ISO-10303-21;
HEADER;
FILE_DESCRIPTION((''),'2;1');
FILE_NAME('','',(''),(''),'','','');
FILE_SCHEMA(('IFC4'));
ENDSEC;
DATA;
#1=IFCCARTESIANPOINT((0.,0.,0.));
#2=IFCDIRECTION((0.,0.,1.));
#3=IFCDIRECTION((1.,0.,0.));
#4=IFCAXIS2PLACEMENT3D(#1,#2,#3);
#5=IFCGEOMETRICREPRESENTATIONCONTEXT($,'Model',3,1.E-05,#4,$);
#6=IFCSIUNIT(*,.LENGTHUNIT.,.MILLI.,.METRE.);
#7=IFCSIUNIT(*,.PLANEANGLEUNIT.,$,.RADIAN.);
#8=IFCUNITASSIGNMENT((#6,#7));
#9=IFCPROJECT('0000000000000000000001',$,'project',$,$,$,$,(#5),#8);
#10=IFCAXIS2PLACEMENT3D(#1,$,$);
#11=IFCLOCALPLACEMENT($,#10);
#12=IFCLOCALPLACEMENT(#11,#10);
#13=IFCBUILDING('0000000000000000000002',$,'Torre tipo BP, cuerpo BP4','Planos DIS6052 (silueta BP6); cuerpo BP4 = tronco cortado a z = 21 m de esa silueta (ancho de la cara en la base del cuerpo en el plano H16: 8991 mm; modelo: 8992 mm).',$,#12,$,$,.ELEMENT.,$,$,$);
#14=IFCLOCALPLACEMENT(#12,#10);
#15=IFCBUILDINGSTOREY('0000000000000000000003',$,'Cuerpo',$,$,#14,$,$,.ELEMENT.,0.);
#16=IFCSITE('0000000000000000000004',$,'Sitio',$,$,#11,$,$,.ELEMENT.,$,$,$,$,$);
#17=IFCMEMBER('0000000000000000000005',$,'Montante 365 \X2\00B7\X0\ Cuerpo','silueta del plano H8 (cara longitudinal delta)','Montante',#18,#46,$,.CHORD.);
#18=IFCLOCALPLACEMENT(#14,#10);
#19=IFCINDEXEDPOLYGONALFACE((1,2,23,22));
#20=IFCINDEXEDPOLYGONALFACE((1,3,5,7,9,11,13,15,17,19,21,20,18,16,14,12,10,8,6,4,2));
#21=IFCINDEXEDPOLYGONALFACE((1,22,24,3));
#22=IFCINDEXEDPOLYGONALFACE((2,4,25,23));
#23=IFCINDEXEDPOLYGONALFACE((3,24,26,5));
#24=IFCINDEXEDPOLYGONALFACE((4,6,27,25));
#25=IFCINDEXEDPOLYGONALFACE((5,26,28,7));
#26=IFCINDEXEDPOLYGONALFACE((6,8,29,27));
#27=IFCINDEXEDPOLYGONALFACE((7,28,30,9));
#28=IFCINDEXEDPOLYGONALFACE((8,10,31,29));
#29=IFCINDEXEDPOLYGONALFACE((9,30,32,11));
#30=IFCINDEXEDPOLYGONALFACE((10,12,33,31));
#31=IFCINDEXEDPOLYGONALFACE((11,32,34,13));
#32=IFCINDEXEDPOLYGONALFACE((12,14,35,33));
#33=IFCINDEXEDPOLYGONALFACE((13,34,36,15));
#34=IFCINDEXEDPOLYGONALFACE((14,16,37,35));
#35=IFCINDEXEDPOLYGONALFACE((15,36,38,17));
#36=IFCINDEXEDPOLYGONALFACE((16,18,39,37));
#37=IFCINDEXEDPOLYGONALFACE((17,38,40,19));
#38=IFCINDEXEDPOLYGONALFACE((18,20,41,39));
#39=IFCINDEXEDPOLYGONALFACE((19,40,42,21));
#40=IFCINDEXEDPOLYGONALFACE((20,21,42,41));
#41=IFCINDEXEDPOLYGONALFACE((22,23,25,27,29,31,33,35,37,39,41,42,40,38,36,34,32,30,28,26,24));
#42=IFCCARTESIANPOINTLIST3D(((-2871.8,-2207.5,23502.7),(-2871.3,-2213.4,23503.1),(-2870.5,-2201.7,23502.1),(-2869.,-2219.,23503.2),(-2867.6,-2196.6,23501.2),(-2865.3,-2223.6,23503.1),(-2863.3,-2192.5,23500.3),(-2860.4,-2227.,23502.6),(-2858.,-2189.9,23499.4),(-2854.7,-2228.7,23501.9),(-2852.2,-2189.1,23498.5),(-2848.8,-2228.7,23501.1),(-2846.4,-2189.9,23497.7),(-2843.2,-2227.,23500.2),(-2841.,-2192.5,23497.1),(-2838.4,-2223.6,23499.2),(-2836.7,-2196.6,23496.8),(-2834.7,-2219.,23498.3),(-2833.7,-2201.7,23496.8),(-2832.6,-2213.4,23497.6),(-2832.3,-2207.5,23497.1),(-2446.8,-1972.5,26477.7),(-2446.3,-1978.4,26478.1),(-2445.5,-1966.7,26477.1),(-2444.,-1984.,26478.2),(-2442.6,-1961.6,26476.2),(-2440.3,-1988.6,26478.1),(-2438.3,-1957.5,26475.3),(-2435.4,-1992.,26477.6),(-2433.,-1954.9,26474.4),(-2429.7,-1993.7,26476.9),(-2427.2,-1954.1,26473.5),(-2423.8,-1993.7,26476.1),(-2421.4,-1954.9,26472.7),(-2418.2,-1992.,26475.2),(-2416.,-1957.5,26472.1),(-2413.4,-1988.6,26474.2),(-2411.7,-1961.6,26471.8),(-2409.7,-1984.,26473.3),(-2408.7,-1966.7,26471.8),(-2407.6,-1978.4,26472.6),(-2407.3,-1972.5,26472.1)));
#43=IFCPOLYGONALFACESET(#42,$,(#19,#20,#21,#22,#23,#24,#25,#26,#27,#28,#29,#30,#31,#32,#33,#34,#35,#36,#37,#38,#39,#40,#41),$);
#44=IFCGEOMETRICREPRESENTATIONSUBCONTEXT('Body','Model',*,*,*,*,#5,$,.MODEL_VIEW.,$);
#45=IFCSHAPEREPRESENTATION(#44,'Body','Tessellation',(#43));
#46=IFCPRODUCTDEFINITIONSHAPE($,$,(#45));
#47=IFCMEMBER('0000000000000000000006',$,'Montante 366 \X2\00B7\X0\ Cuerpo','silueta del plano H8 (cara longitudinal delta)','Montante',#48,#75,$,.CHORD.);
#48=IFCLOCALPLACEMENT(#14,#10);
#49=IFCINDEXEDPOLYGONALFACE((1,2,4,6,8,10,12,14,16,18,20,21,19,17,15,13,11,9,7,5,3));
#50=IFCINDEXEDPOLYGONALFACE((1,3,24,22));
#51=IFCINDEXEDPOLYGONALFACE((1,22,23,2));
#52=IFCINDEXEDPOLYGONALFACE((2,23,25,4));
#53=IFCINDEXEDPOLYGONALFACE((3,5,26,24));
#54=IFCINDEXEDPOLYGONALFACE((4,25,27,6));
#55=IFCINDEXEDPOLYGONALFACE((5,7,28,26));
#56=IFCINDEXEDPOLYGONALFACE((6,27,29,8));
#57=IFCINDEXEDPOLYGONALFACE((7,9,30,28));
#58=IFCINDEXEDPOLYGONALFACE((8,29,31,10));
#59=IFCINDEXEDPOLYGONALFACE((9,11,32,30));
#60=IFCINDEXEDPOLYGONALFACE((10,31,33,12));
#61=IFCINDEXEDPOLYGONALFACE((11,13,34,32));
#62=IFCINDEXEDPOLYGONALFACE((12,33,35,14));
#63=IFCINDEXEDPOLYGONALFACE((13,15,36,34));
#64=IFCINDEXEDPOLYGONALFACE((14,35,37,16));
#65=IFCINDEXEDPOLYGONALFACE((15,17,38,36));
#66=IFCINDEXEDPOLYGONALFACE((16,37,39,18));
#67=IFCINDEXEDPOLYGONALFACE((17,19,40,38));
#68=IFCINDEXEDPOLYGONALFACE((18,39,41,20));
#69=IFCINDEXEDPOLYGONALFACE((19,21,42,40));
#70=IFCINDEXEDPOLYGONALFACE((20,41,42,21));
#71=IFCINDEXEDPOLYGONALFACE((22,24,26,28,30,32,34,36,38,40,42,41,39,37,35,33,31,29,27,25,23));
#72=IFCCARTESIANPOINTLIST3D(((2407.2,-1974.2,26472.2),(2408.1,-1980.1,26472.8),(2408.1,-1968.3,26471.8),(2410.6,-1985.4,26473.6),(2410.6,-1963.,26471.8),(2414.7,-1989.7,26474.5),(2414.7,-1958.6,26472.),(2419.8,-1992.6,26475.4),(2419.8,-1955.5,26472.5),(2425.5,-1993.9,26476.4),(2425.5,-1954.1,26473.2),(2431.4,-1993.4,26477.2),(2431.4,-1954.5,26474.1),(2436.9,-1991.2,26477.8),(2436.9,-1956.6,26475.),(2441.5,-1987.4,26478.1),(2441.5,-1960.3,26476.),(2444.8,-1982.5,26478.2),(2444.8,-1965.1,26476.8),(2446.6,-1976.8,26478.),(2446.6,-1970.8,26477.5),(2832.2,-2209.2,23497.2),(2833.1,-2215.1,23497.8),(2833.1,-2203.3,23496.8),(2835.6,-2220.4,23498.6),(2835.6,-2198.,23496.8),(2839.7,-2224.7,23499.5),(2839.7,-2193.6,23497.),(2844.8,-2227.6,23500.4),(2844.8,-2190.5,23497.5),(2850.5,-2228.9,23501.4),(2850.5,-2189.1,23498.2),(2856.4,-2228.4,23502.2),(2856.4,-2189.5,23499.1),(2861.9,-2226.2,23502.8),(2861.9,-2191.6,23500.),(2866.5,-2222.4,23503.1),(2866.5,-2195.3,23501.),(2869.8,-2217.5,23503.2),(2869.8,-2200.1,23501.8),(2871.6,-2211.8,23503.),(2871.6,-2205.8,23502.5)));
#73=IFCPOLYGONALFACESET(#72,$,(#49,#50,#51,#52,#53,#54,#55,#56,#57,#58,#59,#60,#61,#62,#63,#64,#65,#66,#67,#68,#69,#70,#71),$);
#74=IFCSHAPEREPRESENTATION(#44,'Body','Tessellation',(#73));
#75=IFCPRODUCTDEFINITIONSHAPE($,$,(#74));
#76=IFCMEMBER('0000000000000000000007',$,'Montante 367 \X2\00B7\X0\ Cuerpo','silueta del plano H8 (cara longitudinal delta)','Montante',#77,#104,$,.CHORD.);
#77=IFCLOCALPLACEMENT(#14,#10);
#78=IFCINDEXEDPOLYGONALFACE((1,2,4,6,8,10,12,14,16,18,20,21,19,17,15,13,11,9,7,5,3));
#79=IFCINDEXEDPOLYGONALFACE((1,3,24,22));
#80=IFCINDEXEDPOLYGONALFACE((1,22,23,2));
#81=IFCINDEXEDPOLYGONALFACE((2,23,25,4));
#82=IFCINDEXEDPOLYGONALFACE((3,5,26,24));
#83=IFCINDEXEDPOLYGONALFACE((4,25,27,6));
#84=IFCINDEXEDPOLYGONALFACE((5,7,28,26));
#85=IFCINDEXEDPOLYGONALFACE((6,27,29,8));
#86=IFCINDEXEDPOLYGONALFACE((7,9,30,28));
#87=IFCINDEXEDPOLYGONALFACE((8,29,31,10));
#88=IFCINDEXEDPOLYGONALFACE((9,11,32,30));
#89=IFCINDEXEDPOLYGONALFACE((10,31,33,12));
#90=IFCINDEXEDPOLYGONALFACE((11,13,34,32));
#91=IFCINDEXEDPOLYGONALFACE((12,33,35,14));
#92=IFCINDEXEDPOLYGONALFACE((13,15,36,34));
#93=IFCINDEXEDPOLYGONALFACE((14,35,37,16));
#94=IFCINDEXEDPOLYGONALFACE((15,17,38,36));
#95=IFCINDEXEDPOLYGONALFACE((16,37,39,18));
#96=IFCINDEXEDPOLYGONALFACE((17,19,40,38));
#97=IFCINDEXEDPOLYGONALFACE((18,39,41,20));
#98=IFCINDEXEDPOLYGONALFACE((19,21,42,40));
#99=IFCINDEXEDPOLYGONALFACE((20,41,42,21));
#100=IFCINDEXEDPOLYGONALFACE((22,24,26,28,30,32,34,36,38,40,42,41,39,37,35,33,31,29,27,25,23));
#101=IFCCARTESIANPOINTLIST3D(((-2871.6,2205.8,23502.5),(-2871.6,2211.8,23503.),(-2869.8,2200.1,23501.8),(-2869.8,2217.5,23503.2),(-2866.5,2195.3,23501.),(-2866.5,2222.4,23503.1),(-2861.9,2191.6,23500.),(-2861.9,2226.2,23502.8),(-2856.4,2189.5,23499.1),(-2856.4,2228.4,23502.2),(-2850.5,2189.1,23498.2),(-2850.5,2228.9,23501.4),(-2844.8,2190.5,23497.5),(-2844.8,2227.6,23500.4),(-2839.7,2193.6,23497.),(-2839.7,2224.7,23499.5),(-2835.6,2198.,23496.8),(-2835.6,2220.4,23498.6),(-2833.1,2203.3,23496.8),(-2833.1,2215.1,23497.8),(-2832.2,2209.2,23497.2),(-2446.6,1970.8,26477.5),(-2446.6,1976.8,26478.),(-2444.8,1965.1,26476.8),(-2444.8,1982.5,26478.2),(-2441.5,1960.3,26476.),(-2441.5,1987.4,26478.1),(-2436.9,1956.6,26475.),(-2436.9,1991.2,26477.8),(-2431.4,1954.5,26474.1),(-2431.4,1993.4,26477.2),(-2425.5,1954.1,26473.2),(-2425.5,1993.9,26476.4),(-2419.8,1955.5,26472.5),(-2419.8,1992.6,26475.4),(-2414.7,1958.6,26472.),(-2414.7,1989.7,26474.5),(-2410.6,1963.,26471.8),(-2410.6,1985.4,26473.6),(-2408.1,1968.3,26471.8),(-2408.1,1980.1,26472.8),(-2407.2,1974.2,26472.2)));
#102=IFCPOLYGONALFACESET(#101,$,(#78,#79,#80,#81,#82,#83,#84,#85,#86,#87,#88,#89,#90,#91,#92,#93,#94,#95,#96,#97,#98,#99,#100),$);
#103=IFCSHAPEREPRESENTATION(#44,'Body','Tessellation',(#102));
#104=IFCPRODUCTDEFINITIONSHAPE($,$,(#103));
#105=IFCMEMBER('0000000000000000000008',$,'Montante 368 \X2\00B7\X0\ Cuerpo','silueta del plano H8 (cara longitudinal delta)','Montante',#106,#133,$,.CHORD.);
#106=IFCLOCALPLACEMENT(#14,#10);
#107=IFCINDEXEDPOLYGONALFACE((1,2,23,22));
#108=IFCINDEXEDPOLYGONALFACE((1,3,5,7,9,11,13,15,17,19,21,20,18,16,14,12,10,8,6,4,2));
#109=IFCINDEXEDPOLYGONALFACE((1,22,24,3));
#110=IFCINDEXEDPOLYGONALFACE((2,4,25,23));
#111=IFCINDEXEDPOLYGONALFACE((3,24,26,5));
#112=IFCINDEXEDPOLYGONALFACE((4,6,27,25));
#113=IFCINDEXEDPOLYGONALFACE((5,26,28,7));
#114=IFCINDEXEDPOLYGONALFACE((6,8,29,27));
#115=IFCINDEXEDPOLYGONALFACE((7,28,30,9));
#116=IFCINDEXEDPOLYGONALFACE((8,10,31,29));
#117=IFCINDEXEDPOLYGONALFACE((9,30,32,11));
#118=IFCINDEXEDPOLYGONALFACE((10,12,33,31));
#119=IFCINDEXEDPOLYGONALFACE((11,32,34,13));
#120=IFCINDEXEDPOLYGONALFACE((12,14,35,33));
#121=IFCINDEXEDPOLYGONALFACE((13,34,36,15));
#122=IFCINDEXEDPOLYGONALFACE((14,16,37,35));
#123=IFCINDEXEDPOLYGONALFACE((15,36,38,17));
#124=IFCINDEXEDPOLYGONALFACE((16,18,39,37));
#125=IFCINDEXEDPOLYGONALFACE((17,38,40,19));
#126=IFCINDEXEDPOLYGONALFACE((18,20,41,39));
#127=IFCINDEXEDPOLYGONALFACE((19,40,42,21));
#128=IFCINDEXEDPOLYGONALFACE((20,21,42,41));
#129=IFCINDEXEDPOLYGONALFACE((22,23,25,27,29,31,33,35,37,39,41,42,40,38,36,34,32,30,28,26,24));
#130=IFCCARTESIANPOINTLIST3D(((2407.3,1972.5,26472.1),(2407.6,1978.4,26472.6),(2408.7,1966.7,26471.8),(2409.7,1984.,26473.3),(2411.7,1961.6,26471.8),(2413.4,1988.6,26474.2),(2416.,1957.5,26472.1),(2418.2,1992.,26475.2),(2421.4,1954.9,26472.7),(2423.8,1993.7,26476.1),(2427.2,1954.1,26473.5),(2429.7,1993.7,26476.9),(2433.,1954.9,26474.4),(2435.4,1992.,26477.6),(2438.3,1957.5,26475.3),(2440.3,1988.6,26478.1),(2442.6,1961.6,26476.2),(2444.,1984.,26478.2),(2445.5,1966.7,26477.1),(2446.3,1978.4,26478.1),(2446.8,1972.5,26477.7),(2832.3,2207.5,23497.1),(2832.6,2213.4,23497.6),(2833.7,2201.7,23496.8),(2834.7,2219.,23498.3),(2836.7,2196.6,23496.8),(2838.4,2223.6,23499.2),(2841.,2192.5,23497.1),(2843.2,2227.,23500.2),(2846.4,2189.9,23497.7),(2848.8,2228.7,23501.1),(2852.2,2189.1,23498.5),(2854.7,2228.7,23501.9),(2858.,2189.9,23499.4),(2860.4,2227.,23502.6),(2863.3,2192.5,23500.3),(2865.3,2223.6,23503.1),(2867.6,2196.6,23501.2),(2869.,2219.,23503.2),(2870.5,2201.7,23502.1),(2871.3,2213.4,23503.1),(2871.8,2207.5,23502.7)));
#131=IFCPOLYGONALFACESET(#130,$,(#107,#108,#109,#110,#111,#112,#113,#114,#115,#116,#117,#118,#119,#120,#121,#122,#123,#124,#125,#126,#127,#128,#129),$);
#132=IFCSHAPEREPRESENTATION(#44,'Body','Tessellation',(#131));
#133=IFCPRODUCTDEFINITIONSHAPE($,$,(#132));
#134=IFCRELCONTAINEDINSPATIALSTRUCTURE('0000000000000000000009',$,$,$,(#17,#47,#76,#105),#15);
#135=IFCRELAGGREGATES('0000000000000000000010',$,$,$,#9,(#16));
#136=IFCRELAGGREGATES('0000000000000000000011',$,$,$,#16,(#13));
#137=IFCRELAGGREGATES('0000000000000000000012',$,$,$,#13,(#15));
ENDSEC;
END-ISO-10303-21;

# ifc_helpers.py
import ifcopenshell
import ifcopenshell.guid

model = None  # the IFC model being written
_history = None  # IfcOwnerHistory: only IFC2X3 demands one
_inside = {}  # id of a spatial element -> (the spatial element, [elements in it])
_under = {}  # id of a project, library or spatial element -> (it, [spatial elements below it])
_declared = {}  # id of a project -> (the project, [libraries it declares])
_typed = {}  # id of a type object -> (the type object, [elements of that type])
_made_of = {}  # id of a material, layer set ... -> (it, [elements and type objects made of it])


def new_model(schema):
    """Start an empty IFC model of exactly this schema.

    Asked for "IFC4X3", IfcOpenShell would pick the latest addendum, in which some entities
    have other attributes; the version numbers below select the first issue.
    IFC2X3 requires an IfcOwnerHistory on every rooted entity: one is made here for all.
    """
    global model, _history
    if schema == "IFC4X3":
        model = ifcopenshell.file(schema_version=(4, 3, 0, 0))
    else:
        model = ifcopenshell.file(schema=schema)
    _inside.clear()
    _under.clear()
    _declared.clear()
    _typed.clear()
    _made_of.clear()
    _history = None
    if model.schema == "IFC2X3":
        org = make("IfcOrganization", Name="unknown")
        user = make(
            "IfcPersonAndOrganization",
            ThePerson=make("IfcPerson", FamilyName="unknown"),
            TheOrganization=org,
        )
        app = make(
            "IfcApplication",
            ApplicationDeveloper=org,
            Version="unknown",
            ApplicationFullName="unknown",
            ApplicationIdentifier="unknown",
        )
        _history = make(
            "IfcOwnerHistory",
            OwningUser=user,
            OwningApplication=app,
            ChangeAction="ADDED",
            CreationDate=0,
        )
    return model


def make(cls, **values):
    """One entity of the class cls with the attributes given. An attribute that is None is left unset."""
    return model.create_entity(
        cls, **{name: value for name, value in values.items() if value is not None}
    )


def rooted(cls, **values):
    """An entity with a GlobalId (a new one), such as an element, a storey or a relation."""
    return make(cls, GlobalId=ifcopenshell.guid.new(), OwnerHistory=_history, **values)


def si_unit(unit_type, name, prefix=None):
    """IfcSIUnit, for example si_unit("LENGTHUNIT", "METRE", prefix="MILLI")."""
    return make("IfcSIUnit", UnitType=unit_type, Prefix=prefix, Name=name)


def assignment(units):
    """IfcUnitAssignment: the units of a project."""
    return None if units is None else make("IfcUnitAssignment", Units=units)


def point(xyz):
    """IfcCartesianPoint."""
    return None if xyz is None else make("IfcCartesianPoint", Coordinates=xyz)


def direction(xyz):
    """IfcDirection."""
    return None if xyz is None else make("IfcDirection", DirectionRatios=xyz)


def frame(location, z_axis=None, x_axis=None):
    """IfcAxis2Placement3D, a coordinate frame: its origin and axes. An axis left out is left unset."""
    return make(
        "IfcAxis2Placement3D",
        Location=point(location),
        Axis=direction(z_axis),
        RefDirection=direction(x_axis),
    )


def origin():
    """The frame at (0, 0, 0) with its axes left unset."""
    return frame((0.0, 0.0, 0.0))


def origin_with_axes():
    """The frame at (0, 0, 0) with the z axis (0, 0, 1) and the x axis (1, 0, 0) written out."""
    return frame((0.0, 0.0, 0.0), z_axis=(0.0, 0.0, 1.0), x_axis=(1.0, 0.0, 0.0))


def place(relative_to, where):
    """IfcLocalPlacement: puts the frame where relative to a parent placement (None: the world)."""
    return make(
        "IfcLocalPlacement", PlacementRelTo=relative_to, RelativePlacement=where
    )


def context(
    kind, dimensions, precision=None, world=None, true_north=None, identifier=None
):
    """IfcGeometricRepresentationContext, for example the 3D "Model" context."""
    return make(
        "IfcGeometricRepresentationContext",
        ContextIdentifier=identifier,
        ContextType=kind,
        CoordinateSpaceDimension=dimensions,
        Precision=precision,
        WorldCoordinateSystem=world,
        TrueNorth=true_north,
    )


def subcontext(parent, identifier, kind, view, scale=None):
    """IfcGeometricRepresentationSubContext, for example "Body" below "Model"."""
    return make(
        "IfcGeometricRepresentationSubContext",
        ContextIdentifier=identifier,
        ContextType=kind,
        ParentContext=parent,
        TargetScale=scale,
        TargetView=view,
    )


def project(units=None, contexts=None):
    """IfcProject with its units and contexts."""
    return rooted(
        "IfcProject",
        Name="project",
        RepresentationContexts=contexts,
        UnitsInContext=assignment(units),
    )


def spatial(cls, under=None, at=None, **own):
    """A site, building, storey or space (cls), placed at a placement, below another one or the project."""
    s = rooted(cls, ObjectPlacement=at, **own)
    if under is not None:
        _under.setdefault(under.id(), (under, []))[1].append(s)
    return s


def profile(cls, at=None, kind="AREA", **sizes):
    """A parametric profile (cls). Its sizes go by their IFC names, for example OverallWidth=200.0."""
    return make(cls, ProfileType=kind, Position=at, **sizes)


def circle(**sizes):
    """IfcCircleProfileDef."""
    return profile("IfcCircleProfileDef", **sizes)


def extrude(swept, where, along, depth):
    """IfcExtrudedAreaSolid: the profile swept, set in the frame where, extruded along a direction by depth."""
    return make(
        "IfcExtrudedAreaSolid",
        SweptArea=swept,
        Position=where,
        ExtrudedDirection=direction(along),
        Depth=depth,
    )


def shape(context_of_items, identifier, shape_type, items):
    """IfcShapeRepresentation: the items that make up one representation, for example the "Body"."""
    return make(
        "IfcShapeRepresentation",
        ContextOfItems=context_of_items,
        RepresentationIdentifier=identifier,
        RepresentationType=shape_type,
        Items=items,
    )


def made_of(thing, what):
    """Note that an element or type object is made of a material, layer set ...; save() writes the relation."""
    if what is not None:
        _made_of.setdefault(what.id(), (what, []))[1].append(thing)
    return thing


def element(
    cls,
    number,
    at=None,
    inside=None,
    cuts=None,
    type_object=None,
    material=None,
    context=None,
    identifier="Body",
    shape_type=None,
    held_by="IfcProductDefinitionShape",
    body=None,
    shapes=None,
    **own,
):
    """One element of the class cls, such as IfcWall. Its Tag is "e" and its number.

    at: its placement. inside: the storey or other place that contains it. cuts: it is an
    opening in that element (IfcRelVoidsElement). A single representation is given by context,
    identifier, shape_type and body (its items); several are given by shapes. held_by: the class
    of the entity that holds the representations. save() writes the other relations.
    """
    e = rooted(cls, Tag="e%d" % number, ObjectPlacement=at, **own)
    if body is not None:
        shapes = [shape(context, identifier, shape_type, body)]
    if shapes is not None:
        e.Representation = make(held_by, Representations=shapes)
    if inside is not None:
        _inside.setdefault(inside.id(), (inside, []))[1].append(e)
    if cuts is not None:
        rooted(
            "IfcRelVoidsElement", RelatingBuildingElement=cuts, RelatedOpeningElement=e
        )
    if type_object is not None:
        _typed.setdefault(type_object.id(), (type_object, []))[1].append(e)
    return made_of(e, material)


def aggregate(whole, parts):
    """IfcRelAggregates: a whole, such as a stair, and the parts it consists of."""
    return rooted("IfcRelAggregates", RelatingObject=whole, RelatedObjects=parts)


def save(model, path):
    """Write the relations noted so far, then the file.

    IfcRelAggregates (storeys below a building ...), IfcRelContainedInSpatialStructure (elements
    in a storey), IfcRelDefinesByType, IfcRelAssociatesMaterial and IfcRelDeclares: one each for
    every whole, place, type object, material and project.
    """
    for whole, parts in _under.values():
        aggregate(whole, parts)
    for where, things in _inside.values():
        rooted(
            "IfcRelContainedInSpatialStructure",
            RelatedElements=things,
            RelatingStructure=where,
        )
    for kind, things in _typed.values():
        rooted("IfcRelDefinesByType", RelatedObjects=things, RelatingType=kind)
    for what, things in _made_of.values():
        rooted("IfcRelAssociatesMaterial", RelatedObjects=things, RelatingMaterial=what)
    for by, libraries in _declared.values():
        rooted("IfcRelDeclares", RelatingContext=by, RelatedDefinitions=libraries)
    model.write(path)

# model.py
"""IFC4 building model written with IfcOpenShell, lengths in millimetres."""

from ifc_helpers import new_model, si_unit, frame, origin, origin_with_axes, place, context, subcontext, project, spatial, circle, extrude, element, save


model = new_model("IFC4")

# Units and contexts
model_context = context("Model", 3, precision=1e-05, world=origin_with_axes())
body_context = subcontext(model_context, "Body", "Model", "MODEL_VIEW")
ifc_project = project(units=[si_unit("LENGTHUNIT", "METRE", prefix="MILLI"), si_unit("PLANEANGLEUNIT", "RADIAN")], contexts=[model_context])

# Site, building, storey
site_placement = place(None, origin())
site = spatial("IfcSite", under=ifc_project, at=site_placement, Name="Sitio", CompositionType="ELEMENT")
building_placement = place(site_placement, origin())
building = spatial("IfcBuilding", under=site, at=building_placement, Name="Torre tipo BP, cuerpo BP4", Description="Planos DIS6052 (silueta BP6); cuerpo BP4 = tronco cortado a z = 21 m de esa silueta (ancho de la cara en la base del cuerpo en el plano H16: 8991 mm; modelo: 8992 mm).", CompositionType="ELEMENT")
storey_placement = place(building_placement, origin())
storey = spatial("IfcBuildingStorey", under=building, at=storey_placement, Name="Cuerpo", CompositionType="ELEMENT", Elevation=0.0)

# Members
for number, where, z_axis, x_axis, name in (
    (1, (-2427.0, -1974.0, 26475.0), (-0.140991, -0.07796, -0.986937), (-0.011025, 0.996957, -0.077176), "Montante 365 · Cuerpo"),
    (2, (2427.0, -1974.0, 26475.0), (0.140991, -0.07796, -0.986937), (-0.990011, -0.011103, -0.140553), "Montante 366 · Cuerpo"),
    (3, (-2427.0, 1974.0, 26475.0), (-0.140991, 0.07796, -0.986937), (0.990011, 0.011103, -0.140553), "Montante 367 · Cuerpo"),
    (4, (2427.0, 1974.0, 26475.0), (0.140991, 0.07796, -0.986937), (0.011025, -0.996957, -0.077176), "Montante 368 · Cuerpo"),
):
    element("IfcMember", number, at=place(storey_placement, frame(where, z_axis=z_axis, x_axis=x_axis)), inside=storey, Name=name, Description="silueta del plano H8 (cara longitudinal delta)", ObjectType="Montante", PredefinedType="CHORD", context=body_context, shape_type="SweptSolid", body=[
        extrude(circle(Radius=20.0), None, (0.0, 0.0, 1.0), 3014.4),
    ])

save(model, "model.ifc")
